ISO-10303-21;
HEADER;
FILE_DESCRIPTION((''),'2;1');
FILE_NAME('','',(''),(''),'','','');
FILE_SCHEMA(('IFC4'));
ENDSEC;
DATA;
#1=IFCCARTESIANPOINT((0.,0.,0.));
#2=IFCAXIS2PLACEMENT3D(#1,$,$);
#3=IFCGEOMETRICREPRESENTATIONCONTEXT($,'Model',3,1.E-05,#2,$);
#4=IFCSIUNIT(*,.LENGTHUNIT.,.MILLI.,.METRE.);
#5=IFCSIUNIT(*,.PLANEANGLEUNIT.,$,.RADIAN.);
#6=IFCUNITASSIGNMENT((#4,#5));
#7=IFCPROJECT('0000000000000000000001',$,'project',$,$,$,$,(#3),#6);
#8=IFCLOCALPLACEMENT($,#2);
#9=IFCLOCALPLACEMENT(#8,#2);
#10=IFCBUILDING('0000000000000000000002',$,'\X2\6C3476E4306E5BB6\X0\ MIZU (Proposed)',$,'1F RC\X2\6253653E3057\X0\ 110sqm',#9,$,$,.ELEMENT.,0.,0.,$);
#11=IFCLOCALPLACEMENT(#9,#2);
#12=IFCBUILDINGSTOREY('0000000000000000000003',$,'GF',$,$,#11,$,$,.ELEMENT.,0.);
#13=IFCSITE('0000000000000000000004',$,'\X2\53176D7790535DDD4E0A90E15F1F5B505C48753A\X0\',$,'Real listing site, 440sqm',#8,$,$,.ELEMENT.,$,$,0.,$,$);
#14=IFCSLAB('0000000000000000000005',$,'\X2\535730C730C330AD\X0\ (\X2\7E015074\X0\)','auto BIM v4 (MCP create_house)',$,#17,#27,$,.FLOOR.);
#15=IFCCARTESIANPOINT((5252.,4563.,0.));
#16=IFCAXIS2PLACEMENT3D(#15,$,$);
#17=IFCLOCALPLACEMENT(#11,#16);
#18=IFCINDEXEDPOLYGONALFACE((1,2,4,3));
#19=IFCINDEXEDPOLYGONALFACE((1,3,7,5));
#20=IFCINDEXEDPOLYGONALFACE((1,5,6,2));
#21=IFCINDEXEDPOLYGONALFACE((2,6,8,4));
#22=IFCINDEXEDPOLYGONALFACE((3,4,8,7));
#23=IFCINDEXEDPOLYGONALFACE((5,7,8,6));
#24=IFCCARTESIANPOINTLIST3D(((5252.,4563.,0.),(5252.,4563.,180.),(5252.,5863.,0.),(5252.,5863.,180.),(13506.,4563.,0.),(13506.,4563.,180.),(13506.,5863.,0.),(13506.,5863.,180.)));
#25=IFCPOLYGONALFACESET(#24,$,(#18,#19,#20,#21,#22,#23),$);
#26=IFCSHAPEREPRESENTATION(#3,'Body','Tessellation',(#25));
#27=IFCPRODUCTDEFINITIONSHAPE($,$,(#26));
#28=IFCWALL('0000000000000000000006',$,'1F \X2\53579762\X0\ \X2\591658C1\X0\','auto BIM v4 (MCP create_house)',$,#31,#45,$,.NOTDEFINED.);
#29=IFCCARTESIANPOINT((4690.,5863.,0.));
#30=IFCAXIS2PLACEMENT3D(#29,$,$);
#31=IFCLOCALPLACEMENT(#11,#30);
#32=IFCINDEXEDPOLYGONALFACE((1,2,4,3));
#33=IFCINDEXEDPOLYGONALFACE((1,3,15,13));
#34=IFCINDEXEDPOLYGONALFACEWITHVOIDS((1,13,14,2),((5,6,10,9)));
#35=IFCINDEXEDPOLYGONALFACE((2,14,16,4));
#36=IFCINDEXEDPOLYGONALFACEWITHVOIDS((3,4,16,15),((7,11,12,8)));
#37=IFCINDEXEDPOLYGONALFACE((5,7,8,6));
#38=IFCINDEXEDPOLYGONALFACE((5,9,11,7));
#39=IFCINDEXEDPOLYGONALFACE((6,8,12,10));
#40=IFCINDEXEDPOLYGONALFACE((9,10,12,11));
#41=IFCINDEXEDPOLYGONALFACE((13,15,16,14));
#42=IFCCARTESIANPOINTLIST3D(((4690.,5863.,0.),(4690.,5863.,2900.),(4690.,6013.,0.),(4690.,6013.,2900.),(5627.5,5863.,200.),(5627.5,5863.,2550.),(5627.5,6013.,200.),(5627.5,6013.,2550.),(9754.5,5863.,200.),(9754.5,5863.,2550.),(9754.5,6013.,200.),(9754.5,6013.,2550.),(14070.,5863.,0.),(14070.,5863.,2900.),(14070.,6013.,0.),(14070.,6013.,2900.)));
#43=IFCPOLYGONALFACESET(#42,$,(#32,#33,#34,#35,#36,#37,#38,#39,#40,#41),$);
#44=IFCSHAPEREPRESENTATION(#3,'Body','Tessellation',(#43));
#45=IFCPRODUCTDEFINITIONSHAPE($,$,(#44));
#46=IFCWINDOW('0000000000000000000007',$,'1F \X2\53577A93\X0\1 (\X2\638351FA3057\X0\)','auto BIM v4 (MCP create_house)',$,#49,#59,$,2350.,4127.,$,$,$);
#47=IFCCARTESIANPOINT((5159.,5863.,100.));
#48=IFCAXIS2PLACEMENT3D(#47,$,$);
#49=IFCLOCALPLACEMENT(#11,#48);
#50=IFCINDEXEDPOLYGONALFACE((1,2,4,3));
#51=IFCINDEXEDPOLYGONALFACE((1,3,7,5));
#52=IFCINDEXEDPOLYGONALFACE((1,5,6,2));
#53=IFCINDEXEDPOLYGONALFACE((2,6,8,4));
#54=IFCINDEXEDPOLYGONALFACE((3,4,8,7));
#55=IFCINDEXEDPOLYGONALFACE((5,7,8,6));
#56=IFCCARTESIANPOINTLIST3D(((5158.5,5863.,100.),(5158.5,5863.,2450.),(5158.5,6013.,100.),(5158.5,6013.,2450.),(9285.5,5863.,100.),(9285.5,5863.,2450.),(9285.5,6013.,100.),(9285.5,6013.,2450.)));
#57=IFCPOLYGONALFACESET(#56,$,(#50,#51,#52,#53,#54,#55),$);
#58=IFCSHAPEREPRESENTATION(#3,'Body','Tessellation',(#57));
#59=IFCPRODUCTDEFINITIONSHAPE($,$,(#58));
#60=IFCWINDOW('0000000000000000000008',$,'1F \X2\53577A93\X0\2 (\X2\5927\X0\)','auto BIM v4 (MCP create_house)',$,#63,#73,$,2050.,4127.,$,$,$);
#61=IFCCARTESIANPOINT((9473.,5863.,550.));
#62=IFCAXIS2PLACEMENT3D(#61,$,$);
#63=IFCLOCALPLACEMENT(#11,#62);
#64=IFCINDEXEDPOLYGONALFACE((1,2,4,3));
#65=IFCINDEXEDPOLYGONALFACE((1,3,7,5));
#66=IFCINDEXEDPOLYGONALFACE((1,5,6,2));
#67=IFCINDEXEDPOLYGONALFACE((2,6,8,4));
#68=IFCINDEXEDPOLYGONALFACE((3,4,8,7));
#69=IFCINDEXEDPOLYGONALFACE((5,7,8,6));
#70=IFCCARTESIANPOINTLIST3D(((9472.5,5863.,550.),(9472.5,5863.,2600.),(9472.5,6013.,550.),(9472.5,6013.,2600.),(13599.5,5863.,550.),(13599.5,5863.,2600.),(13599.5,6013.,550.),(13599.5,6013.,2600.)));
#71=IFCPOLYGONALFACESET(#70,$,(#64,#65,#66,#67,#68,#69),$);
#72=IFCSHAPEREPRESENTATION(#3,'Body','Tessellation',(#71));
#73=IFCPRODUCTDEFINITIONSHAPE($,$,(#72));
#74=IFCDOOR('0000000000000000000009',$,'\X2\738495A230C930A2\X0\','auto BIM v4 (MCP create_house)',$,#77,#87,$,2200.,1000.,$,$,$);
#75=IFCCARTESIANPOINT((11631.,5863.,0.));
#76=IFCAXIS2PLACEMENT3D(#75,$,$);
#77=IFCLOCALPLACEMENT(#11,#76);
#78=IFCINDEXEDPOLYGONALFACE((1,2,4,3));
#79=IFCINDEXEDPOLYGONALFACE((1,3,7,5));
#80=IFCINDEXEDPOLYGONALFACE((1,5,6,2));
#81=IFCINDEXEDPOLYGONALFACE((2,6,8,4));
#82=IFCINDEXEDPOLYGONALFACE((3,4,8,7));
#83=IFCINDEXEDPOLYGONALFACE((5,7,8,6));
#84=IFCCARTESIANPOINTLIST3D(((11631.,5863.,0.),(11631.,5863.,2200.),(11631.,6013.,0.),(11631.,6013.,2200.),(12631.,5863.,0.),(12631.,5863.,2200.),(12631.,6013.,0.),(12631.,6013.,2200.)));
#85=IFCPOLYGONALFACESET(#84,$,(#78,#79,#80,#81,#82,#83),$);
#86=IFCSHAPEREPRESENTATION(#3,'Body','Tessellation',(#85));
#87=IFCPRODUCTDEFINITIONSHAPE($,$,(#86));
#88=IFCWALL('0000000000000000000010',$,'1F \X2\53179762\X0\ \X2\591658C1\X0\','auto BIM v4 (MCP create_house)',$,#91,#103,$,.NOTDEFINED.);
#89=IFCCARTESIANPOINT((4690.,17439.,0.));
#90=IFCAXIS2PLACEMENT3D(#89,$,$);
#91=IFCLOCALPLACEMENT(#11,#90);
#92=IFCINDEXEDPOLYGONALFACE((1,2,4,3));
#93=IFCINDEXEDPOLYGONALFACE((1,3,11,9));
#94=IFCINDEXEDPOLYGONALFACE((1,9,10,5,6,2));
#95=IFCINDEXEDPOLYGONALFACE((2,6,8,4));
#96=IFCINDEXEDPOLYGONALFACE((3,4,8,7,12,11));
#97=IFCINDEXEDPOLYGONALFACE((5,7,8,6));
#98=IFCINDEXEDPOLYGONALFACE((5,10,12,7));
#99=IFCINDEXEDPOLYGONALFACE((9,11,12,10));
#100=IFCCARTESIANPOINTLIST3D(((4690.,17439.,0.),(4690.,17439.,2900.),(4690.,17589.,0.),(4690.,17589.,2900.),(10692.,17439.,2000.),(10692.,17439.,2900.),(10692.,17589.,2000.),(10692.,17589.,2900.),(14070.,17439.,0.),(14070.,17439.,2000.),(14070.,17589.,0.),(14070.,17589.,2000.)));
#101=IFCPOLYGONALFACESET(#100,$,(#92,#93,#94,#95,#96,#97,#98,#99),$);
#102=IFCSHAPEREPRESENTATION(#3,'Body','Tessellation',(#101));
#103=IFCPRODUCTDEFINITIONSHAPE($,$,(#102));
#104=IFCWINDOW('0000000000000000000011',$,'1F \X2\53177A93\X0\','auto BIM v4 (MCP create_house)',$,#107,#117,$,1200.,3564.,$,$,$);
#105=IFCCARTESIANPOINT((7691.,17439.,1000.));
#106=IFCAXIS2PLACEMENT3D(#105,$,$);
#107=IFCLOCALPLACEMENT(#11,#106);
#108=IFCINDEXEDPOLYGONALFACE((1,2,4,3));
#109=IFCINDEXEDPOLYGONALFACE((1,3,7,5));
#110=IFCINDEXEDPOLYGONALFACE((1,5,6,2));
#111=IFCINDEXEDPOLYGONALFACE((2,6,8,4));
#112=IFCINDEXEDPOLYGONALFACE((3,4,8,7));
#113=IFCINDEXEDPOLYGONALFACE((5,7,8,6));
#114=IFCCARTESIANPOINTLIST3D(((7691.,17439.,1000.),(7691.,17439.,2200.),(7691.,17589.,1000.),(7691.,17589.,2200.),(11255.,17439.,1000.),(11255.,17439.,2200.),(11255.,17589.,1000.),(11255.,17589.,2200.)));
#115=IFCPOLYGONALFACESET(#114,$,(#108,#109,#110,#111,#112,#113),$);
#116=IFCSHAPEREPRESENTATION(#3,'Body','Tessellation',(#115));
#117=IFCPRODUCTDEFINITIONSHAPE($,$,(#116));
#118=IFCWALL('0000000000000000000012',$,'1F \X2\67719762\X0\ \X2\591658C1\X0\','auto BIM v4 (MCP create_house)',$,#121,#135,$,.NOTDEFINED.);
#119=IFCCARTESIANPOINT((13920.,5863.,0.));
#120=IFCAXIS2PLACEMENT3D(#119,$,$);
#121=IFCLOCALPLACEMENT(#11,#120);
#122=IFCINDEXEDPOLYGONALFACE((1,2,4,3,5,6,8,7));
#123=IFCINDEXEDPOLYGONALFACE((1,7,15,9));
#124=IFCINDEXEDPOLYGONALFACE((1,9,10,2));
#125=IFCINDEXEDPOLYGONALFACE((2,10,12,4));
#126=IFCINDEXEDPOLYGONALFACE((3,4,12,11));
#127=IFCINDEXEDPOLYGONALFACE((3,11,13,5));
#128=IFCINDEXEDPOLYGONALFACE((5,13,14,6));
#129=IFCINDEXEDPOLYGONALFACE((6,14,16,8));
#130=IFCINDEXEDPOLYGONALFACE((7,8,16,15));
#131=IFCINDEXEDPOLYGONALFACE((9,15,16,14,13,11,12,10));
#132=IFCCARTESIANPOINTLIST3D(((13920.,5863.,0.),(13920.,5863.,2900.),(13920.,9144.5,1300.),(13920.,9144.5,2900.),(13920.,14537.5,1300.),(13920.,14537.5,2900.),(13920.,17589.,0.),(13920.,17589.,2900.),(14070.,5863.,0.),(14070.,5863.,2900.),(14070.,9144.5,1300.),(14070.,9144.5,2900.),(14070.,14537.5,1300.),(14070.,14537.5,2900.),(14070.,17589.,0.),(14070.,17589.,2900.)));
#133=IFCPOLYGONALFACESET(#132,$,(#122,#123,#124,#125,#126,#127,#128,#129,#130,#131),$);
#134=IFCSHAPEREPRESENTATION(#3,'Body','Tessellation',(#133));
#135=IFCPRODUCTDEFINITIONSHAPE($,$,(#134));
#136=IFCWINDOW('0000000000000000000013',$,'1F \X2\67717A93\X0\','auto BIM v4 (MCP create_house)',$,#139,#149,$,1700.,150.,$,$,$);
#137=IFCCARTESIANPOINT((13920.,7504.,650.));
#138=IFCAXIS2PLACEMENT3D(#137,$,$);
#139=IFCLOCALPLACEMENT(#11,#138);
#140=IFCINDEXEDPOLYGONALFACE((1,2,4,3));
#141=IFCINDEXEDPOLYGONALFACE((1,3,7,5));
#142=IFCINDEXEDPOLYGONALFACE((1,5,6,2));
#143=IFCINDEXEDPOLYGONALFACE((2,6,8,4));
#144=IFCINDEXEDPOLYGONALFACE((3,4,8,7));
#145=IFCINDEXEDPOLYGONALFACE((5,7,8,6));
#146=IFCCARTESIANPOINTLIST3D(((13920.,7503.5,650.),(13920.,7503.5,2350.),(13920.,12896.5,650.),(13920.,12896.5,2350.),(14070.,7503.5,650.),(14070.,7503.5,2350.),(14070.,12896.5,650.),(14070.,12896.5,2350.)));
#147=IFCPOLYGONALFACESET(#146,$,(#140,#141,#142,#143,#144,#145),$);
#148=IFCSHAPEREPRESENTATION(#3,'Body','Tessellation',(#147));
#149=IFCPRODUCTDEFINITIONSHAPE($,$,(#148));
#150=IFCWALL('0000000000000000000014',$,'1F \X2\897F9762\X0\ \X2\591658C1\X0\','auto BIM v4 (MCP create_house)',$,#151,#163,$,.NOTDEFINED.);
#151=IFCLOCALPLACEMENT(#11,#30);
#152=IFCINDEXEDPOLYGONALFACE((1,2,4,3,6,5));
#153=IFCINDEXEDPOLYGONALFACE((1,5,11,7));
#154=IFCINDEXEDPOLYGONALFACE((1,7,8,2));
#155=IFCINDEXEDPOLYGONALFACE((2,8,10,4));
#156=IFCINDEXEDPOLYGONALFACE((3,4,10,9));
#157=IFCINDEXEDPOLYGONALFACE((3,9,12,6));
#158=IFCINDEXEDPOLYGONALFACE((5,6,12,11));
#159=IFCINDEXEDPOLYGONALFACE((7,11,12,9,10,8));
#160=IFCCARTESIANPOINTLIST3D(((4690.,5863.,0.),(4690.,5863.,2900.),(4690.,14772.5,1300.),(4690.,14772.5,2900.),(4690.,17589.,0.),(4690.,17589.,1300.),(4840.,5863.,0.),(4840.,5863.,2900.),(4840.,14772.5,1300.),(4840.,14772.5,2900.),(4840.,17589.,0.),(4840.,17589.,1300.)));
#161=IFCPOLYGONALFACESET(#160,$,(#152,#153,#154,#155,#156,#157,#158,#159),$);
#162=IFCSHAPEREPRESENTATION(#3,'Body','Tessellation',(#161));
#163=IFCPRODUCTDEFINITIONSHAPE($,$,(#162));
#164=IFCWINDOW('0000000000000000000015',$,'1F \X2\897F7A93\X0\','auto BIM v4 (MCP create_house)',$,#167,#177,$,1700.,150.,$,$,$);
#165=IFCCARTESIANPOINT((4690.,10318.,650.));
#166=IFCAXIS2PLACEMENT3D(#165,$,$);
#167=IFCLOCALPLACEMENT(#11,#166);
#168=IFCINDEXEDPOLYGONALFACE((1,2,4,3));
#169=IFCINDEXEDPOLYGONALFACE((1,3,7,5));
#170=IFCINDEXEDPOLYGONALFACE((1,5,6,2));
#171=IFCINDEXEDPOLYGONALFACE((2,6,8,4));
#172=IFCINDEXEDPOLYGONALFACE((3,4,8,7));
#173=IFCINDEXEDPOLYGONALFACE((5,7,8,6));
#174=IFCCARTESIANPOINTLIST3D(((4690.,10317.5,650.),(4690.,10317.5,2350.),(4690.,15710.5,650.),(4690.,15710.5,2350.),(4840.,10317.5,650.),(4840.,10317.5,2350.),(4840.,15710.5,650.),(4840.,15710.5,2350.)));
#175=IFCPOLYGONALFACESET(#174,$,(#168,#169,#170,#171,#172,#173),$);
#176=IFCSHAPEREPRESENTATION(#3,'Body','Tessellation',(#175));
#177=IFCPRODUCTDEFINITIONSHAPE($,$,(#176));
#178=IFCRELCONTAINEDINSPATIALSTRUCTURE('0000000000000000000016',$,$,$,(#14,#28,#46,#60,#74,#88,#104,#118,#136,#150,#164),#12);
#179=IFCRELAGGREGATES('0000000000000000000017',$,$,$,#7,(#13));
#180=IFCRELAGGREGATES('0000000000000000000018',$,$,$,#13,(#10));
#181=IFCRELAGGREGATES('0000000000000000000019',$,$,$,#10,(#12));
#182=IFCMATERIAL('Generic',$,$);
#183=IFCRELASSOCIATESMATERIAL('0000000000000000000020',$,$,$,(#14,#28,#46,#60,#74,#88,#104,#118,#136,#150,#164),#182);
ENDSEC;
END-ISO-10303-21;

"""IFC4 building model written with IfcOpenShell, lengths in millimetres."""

from ifc_helpers import new_model, si_unit, frame, frame_2d, origin, place, context, project, spatial, rectangle, extrude, material, element, fill, save


model = new_model("IFC4")

# Units and contexts
model_context = context("Model", 3, precision=1e-05, world=origin())
ifc_project = project(units=[si_unit("LENGTHUNIT", "METRE", prefix="MILLI"), si_unit("PLANEANGLEUNIT", "RADIAN")], contexts=[model_context])

# Site, building, storey
site_placement = place(None, origin())
site = spatial("IfcSite", under=ifc_project, at=site_placement, Name="北海道川上郡弟子屈町", ObjectType="Real listing site, 440sqm", CompositionType="ELEMENT", RefElevation=0.0)
building_placement = place(site_placement, origin())
building = spatial("IfcBuilding", under=site, at=building_placement, Name="水盤の家 MIZU (Proposed)", ObjectType="1F RC打放し 110sqm", CompositionType="ELEMENT", ElevationOfRefHeight=0.0, ElevationOfTerrain=0.0)
storey_placement = place(building_placement, origin())
storey = spatial("IfcBuildingStorey", under=building, at=storey_placement, Name="GF", CompositionType="ELEMENT", Elevation=0.0)

# Slab
ifc_material = material(Name="Generic")
slab_1_placement = place(storey_placement, frame((5252.0, 4563.0, 0.0)))
element("IfcSlab", 1, at=slab_1_placement, inside=storey, material=ifc_material, Name="南デッキ (縁側)", Description="auto BIM v4 (MCP create_house)", PredefinedType="FLOOR", context=model_context, shape_type="SweptSolid", body=[
    extrude(rectangle(XDim=8254.0, YDim=1300.0, at=frame_2d((4127.0, 650.0))), frame((5252.0, 4563.0, 0.0)), (0.0, 0.0, 1.0), 180.0),
])

# Wall, openings, windows, door
wall_1_placement = place(storey_placement, frame((4690.0, 5863.0, 0.0)))
wall_1 = element("IfcWall", 2, at=wall_1_placement, inside=storey, material=ifc_material, Name="1F 南面 外壁", Description="auto BIM v4 (MCP create_house)", PredefinedType="NOTDEFINED", context=model_context, shape_type="SweptSolid", body=[
    extrude(rectangle(XDim=9380.0, YDim=150.0, at=frame_2d((4690.0, 75.0))), frame((4690.0, 5863.0, 0.0)), (0.0, 0.0, 1.0), 2900.0),
])
opening_1_placement = place(storey_placement, frame((5159.0, 5863.0, 100.0)))
opening_1 = element("IfcOpeningElement", 3, at=opening_1_placement, cuts=wall_1, PredefinedType="NOTDEFINED", context=model_context, shape_type="SweptSolid", body=[
    extrude(rectangle(XDim=4127.0, YDim=150.0, at=frame_2d((2063.0, 75.0))), frame((5159.0, 5863.0, 100.0)), (0.0, 0.0, 1.0), 2350.0),
])
opening_2_placement = place(storey_placement, frame((9473.0, 5863.0, 550.0)))
opening_2 = element("IfcOpeningElement", 4, at=opening_2_placement, cuts=wall_1, PredefinedType="NOTDEFINED", context=model_context, shape_type="SweptSolid", body=[
    extrude(rectangle(XDim=4127.0, YDim=150.0, at=frame_2d((2063.0, 75.0))), frame((9473.0, 5863.0, 550.0)), (0.0, 0.0, 1.0), 2050.0),
])
opening_3_placement = place(storey_placement, frame((11631.0, 5863.0, 0.0)))
opening_3 = element("IfcOpeningElement", 5, at=opening_3_placement, cuts=wall_1, PredefinedType="NOTDEFINED", context=model_context, shape_type="SweptSolid", body=[
    extrude(rectangle(XDim=1000.0, YDim=150.0, at=frame_2d((500.0, 75.0))), frame((11631.0, 5863.0, 0.0)), (0.0, 0.0, 1.0), 2200.0),
])
window_1_placement = place(storey_placement, frame((5159.0, 5863.0, 100.0)))
window_1 = element("IfcWindow", 6, at=window_1_placement, inside=storey, material=ifc_material, Name="1F 南窓1 (掃出し)", Description="auto BIM v4 (MCP create_house)", OverallHeight=2350.0, OverallWidth=4127.0, context=model_context, shape_type="SweptSolid", body=[
    extrude(rectangle(XDim=4127.0, YDim=150.0, at=frame_2d((2063.0, 75.0))), frame((5159.0, 5863.0, 100.0)), (0.0, 0.0, 1.0), 2350.0),
])
fill(opening_1, window_1)
window_2_placement = place(storey_placement, frame((9473.0, 5863.0, 550.0)))
window_2 = element("IfcWindow", 7, at=window_2_placement, inside=storey, material=ifc_material, Name="1F 南窓2 (大)", Description="auto BIM v4 (MCP create_house)", OverallHeight=2050.0, OverallWidth=4127.0, context=model_context, shape_type="SweptSolid", body=[
    extrude(rectangle(XDim=4127.0, YDim=150.0, at=frame_2d((2063.0, 75.0))), frame((9473.0, 5863.0, 550.0)), (0.0, 0.0, 1.0), 2050.0),
])
fill(opening_2, window_2)
door_placement = place(storey_placement, frame((11631.0, 5863.0, 0.0)))
door = element("IfcDoor", 8, at=door_placement, inside=storey, material=ifc_material, Name="玄関ドア", Description="auto BIM v4 (MCP create_house)", OverallHeight=2200.0, OverallWidth=1000.0, context=model_context, shape_type="SweptSolid", body=[
    extrude(rectangle(XDim=1000.0, YDim=150.0, at=frame_2d((500.0, 75.0))), frame((11631.0, 5863.0, 0.0)), (0.0, 0.0, 1.0), 2200.0),
])
fill(opening_3, door)

# Walls, openings, windows
wall_2_placement = place(storey_placement, frame((4690.0, 17439.0, 0.0)))
wall_2 = element("IfcWall", 9, at=wall_2_placement, inside=storey, material=ifc_material, Name="1F 北面 外壁", Description="auto BIM v4 (MCP create_house)", PredefinedType="NOTDEFINED", context=model_context, shape_type="SweptSolid", body=[
    extrude(rectangle(XDim=9380.0, YDim=150.0, at=frame_2d((4690.0, 75.0))), frame((4690.0, 17439.0, 0.0)), (0.0, 0.0, 1.0), 2900.0),
])
opening_4_placement = place(storey_placement, frame((7691.0, 17439.0, 1000.0)))
opening_4 = element("IfcOpeningElement", 10, at=opening_4_placement, cuts=wall_2, PredefinedType="NOTDEFINED", context=model_context, shape_type="SweptSolid", body=[
    extrude(rectangle(XDim=3564.0, YDim=150.0, at=frame_2d((1782.0, 75.0))), frame((7691.0, 17439.0, 1000.0)), (0.0, 0.0, 1.0), 1200.0),
])
window_3_placement = place(storey_placement, frame((7691.0, 17439.0, 1000.0)))
window_3 = element("IfcWindow", 11, at=window_3_placement, inside=storey, material=ifc_material, Name="1F 北窓", Description="auto BIM v4 (MCP create_house)", OverallHeight=1200.0, OverallWidth=3564.0, context=model_context, shape_type="SweptSolid", body=[
    extrude(rectangle(XDim=3564.0, YDim=150.0, at=frame_2d((1782.0, 75.0))), frame((7691.0, 17439.0, 1000.0)), (0.0, 0.0, 1.0), 1200.0),
])
fill(opening_4, window_3)
wall_3_placement = place(storey_placement, frame((13920.0, 5863.0, 0.0)))
wall_3 = element("IfcWall", 12, at=wall_3_placement, inside=storey, material=ifc_material, Name="1F 東面 外壁", Description="auto BIM v4 (MCP create_house)", PredefinedType="NOTDEFINED", context=model_context, shape_type="SweptSolid", body=[
    extrude(rectangle(XDim=150.0, YDim=11726.0, at=frame_2d((75.0, 5863.0))), frame((13920.0, 5863.0, 0.0)), (0.0, 0.0, 1.0), 2900.0),
])
opening_5_placement = place(storey_placement, frame((13920.0, 7504.0, 650.0)))
opening_5 = element("IfcOpeningElement", 13, at=opening_5_placement, cuts=wall_3, PredefinedType="NOTDEFINED", context=model_context, shape_type="SweptSolid", body=[
    extrude(rectangle(XDim=150.0, YDim=5393.0, at=frame_2d((75.0, 2696.0))), frame((13920.0, 7504.0, 650.0)), (0.0, 0.0, 1.0), 1700.0),
])
window_4_placement = place(storey_placement, frame((13920.0, 7504.0, 650.0)))
window_4 = element("IfcWindow", 14, at=window_4_placement, inside=storey, material=ifc_material, Name="1F 東窓", Description="auto BIM v4 (MCP create_house)", OverallHeight=1700.0, OverallWidth=150.0, context=model_context, shape_type="SweptSolid", body=[
    extrude(rectangle(XDim=150.0, YDim=5393.0, at=frame_2d((75.0, 2696.0))), frame((13920.0, 7504.0, 650.0)), (0.0, 0.0, 1.0), 1700.0),
])
fill(opening_5, window_4)
wall_4_placement = place(storey_placement, frame((4690.0, 5863.0, 0.0)))
wall_4 = element("IfcWall", 15, at=wall_4_placement, inside=storey, material=ifc_material, Name="1F 西面 外壁", Description="auto BIM v4 (MCP create_house)", PredefinedType="NOTDEFINED", context=model_context, shape_type="SweptSolid", body=[
    extrude(rectangle(XDim=150.0, YDim=11726.0, at=frame_2d((75.0, 5863.0))), frame((4690.0, 5863.0, 0.0)), (0.0, 0.0, 1.0), 2900.0),
])
opening_6_placement = place(storey_placement, frame((4690.0, 10318.0, 650.0)))
opening_6 = element("IfcOpeningElement", 16, at=opening_6_placement, cuts=wall_4, PredefinedType="NOTDEFINED", context=model_context, shape_type="SweptSolid", body=[
    extrude(rectangle(XDim=150.0, YDim=5393.0, at=frame_2d((75.0, 2696.0))), frame((4690.0, 10318.0, 650.0)), (0.0, 0.0, 1.0), 1700.0),
])
window_5_placement = place(storey_placement, frame((4690.0, 10318.0, 650.0)))
window_5 = element("IfcWindow", 17, at=window_5_placement, inside=storey, material=ifc_material, Name="1F 西窓", Description="auto BIM v4 (MCP create_house)", OverallHeight=1700.0, OverallWidth=150.0, context=model_context, shape_type="SweptSolid", body=[
    extrude(rectangle(XDim=150.0, YDim=5393.0, at=frame_2d((75.0, 2696.0))), frame((4690.0, 10318.0, 650.0)), (0.0, 0.0, 1.0), 1700.0),
])
fill(opening_6, window_5)

save(model, "model.ifc")
